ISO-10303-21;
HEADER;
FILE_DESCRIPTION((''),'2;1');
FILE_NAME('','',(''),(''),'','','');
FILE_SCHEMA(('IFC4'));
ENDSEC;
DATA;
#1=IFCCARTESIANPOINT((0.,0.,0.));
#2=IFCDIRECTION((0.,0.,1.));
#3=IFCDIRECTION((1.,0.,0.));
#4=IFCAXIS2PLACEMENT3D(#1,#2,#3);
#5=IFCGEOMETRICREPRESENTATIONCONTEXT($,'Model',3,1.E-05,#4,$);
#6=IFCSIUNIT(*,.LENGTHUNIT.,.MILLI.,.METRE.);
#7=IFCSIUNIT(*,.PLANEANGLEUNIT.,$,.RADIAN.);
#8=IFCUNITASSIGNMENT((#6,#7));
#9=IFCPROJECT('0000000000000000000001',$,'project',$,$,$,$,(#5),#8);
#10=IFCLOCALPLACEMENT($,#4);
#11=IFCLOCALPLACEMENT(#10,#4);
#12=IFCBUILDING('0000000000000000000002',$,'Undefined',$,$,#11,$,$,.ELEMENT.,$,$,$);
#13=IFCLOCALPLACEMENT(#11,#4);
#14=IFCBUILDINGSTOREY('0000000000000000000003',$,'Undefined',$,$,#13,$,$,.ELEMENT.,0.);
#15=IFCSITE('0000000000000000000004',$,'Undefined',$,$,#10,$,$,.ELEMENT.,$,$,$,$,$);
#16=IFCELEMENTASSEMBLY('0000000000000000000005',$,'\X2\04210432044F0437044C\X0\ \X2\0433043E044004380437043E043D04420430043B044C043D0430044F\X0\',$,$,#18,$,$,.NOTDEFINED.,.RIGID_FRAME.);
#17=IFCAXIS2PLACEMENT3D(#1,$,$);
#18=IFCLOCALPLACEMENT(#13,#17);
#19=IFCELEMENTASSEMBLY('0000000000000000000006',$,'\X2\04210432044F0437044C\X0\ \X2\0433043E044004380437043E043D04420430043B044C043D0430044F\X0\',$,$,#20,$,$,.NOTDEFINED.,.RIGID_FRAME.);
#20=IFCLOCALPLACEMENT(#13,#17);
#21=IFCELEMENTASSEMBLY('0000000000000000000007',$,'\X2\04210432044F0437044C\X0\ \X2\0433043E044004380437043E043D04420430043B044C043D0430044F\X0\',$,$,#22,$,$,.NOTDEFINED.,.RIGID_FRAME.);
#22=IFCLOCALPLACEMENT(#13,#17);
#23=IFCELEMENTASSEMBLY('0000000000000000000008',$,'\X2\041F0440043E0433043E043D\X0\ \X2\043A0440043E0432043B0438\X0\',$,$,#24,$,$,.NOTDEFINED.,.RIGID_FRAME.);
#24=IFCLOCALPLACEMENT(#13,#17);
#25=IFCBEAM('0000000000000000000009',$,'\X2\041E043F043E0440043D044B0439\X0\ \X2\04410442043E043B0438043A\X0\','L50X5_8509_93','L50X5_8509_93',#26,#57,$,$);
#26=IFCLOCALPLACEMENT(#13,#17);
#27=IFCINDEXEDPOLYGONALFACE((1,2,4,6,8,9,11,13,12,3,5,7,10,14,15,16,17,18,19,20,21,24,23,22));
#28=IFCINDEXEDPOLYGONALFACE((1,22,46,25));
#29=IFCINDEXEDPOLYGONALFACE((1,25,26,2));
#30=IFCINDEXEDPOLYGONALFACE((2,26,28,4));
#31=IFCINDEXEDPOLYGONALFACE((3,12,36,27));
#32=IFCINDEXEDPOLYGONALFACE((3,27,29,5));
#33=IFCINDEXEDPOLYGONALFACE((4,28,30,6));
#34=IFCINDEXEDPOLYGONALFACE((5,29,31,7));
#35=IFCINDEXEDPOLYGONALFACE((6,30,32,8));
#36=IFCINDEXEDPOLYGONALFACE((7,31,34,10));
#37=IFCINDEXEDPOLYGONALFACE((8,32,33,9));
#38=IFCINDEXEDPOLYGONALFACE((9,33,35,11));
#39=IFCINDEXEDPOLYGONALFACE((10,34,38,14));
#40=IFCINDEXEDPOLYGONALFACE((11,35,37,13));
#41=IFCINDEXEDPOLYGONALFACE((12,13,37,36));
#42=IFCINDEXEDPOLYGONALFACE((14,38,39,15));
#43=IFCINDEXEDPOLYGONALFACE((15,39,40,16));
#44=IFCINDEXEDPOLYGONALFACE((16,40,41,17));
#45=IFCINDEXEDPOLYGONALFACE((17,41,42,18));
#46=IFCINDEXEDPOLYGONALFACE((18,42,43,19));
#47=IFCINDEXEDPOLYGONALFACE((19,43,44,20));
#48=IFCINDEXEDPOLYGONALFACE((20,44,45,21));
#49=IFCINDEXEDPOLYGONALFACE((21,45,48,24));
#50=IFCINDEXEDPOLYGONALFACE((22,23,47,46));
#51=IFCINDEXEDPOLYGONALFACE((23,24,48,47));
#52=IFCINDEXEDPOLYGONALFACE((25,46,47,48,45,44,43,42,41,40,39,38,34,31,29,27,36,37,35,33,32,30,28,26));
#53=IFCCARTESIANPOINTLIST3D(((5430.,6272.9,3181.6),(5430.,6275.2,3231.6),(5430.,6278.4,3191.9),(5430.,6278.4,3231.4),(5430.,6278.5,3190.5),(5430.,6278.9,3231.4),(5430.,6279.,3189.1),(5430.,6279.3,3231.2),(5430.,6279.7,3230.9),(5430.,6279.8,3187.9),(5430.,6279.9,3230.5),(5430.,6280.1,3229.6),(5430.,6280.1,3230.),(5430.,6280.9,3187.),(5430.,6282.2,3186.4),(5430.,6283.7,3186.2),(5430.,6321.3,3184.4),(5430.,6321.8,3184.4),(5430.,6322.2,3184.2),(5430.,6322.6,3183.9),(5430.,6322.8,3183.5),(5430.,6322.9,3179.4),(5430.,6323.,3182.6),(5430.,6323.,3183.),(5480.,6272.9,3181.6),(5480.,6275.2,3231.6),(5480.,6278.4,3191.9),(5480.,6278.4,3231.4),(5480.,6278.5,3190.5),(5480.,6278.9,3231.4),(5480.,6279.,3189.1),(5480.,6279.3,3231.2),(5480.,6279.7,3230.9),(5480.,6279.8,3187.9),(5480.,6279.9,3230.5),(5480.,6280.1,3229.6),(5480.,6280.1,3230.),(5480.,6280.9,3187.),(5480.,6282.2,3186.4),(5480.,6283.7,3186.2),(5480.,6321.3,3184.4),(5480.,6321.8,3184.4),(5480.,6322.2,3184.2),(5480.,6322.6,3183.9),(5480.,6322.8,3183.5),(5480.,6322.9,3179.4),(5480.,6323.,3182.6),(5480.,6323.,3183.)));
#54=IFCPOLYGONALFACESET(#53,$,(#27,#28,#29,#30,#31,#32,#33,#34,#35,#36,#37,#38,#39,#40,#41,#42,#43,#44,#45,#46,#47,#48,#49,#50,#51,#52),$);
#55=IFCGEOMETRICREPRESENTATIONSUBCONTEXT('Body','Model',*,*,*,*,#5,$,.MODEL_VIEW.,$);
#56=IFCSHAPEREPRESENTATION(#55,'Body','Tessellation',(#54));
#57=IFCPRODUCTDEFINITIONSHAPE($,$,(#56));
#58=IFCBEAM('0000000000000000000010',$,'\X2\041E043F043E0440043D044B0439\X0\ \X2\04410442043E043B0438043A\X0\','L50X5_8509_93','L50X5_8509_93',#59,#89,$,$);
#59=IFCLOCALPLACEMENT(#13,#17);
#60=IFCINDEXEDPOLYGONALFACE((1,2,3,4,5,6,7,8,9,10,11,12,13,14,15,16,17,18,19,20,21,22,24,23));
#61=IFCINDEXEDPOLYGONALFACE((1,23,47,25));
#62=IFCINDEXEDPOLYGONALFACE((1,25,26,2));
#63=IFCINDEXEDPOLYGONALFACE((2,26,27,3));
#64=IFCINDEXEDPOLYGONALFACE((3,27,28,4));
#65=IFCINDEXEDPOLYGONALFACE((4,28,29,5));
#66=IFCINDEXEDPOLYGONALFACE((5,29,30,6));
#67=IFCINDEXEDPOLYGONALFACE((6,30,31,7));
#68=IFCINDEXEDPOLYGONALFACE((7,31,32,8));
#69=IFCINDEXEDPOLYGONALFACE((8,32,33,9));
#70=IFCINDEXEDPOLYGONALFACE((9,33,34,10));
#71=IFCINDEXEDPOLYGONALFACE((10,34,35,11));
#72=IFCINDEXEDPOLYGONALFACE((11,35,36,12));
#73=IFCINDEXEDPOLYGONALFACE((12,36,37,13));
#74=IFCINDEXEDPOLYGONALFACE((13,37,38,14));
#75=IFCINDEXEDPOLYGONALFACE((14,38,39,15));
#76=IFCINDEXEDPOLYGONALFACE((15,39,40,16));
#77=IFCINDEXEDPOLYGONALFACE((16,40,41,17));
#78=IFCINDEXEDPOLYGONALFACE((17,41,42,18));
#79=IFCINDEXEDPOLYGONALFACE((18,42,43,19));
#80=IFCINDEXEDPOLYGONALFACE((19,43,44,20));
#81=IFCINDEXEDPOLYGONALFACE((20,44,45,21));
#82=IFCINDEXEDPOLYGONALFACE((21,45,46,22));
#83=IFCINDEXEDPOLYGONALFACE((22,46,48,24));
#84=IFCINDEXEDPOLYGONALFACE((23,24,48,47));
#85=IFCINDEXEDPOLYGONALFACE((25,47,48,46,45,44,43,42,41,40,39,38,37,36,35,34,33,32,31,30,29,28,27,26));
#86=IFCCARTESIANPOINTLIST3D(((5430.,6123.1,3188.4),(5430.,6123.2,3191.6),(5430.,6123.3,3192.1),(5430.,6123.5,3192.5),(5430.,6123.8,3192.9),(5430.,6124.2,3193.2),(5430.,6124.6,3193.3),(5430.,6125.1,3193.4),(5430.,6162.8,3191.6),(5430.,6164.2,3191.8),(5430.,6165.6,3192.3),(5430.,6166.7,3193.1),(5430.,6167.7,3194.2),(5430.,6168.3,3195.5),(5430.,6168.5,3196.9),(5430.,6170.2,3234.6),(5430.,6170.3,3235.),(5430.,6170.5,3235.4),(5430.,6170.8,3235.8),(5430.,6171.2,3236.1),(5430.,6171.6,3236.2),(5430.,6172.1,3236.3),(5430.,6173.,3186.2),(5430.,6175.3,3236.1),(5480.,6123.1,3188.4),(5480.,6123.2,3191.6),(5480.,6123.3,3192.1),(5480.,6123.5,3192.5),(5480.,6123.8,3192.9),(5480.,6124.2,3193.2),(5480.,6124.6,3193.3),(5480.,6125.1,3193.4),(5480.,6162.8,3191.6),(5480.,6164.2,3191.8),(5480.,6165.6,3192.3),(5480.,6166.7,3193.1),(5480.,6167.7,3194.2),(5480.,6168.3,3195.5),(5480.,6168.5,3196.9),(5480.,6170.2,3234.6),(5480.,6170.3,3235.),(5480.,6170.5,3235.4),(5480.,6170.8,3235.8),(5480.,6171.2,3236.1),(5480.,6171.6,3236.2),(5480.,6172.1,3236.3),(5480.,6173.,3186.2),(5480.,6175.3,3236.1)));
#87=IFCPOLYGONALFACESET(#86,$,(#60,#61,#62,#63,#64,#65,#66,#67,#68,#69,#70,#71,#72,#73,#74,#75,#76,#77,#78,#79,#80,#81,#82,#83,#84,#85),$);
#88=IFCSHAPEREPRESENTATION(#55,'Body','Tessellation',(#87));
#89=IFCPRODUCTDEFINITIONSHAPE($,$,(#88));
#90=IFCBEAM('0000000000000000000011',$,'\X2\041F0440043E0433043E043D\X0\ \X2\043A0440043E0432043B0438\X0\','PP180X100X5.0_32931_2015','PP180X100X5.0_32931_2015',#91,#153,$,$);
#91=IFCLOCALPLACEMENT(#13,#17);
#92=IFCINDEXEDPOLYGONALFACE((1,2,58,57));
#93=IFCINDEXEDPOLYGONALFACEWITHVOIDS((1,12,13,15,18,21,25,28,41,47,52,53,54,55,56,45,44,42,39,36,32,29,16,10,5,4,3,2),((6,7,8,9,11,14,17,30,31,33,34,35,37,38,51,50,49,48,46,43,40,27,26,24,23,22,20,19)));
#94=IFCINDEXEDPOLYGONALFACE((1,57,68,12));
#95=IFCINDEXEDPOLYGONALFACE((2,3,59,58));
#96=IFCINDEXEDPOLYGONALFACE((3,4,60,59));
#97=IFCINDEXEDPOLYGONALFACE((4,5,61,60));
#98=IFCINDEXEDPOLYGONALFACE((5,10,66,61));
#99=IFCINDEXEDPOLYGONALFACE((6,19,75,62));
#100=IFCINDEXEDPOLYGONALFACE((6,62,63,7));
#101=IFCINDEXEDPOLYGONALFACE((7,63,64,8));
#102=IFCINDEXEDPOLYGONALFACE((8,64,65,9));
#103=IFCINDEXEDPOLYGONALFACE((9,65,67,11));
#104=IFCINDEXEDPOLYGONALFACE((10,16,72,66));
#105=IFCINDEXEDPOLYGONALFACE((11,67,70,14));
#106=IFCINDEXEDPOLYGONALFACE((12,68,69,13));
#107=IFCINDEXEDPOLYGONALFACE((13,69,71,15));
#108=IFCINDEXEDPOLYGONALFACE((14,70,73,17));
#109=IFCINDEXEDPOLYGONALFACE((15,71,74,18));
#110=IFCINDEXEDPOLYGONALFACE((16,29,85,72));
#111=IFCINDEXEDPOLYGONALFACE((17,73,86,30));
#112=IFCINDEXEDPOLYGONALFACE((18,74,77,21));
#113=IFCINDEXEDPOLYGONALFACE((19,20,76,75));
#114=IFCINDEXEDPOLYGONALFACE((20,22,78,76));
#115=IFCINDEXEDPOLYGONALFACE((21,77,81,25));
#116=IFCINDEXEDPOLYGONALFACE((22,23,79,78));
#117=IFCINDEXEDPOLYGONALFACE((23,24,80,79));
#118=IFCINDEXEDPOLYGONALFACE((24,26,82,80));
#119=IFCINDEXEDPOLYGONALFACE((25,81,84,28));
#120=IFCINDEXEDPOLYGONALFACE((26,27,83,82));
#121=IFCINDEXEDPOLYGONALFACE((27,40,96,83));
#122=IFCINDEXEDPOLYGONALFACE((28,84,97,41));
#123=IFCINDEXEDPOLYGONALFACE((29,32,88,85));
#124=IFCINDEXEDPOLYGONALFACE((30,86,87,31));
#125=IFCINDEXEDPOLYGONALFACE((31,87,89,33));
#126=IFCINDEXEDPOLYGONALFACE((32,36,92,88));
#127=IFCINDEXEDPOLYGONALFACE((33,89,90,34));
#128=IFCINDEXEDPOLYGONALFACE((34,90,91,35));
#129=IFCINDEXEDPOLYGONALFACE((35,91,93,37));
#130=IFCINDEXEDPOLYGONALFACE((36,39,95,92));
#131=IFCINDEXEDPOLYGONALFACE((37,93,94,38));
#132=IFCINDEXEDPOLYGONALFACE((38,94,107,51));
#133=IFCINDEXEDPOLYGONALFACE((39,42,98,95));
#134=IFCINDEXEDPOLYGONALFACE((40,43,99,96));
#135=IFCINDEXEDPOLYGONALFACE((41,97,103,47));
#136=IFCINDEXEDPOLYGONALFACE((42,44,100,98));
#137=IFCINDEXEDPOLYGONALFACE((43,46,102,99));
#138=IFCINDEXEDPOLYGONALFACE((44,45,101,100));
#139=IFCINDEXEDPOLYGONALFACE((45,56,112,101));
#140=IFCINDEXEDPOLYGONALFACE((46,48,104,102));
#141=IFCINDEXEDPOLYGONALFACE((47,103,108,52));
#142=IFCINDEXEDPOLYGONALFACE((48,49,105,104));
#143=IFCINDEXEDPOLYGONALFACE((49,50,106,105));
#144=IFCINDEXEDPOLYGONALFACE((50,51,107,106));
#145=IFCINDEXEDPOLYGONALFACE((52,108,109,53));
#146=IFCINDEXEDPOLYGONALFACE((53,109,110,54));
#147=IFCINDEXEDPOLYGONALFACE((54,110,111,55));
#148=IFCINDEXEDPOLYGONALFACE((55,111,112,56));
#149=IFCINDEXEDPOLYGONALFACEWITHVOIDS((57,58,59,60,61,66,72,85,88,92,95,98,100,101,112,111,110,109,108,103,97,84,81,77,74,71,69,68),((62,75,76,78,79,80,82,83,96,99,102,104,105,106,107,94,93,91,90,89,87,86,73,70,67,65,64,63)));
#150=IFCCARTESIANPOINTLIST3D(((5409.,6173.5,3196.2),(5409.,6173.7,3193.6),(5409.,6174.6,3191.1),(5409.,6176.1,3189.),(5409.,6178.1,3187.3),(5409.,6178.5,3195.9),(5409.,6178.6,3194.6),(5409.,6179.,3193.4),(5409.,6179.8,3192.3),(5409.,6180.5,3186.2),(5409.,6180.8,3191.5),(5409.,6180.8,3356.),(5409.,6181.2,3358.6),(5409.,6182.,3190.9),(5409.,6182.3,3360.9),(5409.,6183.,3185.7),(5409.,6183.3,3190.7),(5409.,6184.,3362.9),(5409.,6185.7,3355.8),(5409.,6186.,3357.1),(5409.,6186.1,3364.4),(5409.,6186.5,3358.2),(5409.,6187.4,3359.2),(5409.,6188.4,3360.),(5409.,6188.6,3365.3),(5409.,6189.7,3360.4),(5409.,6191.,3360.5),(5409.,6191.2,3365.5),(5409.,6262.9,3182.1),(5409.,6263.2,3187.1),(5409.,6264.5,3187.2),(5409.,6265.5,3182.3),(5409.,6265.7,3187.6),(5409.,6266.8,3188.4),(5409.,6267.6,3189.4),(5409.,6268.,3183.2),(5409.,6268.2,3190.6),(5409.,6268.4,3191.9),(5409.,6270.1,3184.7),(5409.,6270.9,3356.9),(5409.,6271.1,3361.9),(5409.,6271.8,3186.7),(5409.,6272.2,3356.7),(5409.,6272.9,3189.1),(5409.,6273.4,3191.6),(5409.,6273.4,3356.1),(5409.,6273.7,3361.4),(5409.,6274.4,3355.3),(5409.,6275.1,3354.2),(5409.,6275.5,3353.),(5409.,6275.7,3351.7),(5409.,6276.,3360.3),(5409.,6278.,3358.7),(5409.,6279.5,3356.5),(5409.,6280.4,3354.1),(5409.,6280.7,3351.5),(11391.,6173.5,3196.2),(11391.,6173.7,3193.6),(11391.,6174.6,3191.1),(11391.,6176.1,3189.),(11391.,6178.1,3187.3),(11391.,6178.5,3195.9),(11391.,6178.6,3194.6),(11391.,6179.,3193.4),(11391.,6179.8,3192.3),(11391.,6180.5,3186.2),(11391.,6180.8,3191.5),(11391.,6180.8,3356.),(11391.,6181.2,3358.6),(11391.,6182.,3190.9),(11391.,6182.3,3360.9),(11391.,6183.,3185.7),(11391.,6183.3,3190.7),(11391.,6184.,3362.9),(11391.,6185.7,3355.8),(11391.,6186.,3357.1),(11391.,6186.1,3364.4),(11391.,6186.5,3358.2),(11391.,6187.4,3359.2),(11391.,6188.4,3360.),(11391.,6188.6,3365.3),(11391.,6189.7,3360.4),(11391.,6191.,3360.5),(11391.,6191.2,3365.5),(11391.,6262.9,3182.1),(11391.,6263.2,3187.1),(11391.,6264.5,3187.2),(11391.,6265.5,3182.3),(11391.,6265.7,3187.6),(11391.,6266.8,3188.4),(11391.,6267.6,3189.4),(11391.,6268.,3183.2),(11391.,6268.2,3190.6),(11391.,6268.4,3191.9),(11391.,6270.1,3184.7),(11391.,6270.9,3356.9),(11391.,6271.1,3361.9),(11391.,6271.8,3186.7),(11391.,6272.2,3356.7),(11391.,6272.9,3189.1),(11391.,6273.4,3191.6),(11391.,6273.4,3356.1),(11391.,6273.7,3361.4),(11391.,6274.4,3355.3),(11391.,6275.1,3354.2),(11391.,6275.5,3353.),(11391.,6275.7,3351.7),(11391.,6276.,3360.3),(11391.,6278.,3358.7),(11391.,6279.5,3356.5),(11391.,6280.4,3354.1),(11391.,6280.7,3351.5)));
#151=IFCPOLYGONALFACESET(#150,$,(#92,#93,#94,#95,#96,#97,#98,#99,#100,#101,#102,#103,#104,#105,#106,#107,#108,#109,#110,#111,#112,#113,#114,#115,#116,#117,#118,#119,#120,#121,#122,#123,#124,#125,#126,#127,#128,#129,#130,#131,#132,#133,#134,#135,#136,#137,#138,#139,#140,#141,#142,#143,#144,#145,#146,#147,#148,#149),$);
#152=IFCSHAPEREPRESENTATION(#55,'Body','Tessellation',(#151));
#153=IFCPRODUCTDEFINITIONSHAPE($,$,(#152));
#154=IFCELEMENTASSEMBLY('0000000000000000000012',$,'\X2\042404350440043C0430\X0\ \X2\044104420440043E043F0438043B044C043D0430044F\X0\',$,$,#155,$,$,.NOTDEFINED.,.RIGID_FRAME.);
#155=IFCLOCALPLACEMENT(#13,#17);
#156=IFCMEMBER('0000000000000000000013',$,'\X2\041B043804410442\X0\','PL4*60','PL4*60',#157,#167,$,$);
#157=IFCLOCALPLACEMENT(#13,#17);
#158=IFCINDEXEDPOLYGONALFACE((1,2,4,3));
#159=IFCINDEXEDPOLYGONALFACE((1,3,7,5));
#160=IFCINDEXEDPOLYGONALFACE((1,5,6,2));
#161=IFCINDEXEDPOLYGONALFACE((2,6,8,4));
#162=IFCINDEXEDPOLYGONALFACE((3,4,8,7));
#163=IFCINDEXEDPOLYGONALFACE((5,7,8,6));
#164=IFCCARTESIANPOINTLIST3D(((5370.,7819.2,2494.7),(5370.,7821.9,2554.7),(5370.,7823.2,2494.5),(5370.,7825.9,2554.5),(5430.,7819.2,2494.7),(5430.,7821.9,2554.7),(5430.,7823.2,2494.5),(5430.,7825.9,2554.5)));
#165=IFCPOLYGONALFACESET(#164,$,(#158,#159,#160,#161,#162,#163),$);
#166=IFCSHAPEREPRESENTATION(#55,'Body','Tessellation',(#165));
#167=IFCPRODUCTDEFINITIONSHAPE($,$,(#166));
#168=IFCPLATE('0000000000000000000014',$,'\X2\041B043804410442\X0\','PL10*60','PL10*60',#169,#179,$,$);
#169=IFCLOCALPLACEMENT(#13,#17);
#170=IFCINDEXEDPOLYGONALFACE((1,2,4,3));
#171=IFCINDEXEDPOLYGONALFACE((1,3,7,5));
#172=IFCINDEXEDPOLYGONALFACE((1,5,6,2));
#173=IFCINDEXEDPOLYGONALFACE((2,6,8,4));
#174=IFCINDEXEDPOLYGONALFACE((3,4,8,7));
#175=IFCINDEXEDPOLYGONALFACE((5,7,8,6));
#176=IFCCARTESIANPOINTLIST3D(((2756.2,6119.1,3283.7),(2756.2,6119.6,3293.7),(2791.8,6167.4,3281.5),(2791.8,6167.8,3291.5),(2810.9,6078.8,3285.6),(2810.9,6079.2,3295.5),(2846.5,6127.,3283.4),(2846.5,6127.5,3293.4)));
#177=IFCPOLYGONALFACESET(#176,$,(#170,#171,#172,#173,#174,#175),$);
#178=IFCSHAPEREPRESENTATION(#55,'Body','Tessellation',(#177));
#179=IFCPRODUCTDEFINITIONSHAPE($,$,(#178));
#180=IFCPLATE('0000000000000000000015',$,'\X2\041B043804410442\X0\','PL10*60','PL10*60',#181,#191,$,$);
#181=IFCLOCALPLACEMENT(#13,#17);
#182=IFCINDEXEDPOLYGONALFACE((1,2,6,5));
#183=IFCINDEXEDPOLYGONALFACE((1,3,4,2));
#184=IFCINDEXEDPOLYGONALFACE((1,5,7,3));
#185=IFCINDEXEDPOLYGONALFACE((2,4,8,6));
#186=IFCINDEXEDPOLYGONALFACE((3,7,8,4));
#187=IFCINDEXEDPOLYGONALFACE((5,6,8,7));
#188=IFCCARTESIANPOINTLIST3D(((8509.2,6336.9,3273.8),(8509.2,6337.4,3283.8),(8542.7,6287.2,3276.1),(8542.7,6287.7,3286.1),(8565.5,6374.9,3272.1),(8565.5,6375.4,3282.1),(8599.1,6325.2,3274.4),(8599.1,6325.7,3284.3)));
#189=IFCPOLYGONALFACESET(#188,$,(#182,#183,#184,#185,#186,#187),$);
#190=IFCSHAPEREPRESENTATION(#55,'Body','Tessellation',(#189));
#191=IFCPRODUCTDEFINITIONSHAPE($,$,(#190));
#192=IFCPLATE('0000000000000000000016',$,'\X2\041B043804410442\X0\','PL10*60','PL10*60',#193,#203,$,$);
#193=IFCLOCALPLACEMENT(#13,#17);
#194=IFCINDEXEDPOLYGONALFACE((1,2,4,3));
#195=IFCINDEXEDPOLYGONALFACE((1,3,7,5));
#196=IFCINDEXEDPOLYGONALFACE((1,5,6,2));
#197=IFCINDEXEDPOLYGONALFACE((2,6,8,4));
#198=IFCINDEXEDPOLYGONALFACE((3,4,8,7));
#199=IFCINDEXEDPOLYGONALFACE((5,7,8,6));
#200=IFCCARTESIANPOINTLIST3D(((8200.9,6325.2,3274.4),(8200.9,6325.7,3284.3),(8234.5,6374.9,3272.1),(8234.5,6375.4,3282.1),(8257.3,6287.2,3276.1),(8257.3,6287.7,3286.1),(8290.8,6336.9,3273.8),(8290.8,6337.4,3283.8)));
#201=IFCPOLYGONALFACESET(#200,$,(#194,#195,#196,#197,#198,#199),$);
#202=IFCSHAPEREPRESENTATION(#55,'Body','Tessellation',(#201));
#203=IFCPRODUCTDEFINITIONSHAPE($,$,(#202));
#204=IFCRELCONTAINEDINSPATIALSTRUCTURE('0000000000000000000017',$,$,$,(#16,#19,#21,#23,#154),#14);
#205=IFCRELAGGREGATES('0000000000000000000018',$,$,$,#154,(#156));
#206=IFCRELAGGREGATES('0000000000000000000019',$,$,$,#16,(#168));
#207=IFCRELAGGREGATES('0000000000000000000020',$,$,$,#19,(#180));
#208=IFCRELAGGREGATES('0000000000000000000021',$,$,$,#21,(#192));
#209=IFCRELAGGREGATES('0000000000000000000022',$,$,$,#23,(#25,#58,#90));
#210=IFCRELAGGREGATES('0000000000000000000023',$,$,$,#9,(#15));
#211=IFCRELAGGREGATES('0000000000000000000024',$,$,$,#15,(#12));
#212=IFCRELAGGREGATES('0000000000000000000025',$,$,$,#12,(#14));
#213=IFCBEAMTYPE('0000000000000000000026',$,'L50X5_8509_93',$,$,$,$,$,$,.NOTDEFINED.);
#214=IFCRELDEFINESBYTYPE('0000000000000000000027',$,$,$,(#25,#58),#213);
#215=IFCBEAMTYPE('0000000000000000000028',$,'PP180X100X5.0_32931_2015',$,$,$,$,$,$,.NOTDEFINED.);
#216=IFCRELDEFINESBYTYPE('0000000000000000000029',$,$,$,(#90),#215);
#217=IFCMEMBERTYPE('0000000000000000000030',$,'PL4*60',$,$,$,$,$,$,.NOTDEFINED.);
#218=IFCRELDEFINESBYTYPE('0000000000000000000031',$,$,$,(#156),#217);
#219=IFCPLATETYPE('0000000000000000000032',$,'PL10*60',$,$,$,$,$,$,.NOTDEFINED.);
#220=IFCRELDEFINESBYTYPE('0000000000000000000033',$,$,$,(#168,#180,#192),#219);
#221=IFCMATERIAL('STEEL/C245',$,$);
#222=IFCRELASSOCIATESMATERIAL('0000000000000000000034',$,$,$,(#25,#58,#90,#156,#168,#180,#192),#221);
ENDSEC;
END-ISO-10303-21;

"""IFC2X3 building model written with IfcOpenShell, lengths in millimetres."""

from ifc_helpers import new_model, si_unit, frame, origin_with_axes, origin_2d_with_axis, place, context, subcontext, project, spatial, polyline, rectangle, hollow_rectangle, l_section, outline, extrude, clip, halfspace, material, type_object, element, aggregate, save


model = new_model("IFC2X3")

# Units and contexts
model_context = context("Model", 3, precision=1e-05, world=origin_with_axes())
body_context = subcontext(model_context, "Body", "Model", "MODEL_VIEW")
ifc_project = project(units=[si_unit("LENGTHUNIT", "METRE", prefix="MILLI"), si_unit("PLANEANGLEUNIT", "RADIAN")], contexts=[model_context])

# Site, building, storey
site_placement = place(None, origin_with_axes())
site = spatial("IfcSite", under=ifc_project, at=site_placement, Name="Undefined", CompositionType="ELEMENT")
building_placement = place(site_placement, origin_with_axes())
building = spatial("IfcBuilding", under=site, at=building_placement, Name="Undefined", CompositionType="ELEMENT")
storey_placement = place(building_placement, origin_with_axes())
storey = spatial("IfcBuildingStorey", under=building, at=storey_placement, Name="Undefined", CompositionType="ELEMENT", Elevation=0.0)

# Element assembly
assembly_1_placement = place(storey_placement, origin_with_axes())
assembly_1 = element("IfcElementAssembly", 1, at=assembly_1_placement, inside=storey, Name="Связь горизонтальная", AssemblyPlace="NOTDEFINED", PredefinedType="RIGID_FRAME")
ifc_material_1 = material(Name="STEEL/C245")

# Element assembly
assembly_2_placement = place(storey_placement, origin_with_axes())
assembly_2 = element("IfcElementAssembly", 2, at=assembly_2_placement, inside=storey, Name="Связь горизонтальная", AssemblyPlace="NOTDEFINED", PredefinedType="RIGID_FRAME")

# Element assembly
assembly_3_placement = place(storey_placement, origin_with_axes())
assembly_3 = element("IfcElementAssembly", 3, at=assembly_3_placement, inside=storey, Name="Связь горизонтальная", AssemblyPlace="NOTDEFINED", PredefinedType="RIGID_FRAME")

# Element assembly
assembly_4_placement = place(storey_placement, origin_with_axes())
assembly_4 = element("IfcElementAssembly", 4, at=assembly_4_placement, inside=storey, Name="Прогон кровли", AssemblyPlace="NOTDEFINED", PredefinedType="RIGID_FRAME")

# Beams
beam_type_1 = type_object("IfcBeamType", Name="L50X5_8509_93", PredefinedType="NOTDEFINED")
beam_1_placement = place(assembly_4_placement, frame((5430.0, 6299.0, 3205.5), z_axis=(0.0, 0.998969, -0.045408), x_axis=(1.0, 0.0, 0.0)))
beam_1 = element("IfcBeam", 5, at=beam_1_placement, type_object=beam_type_1, material=ifc_material_1, Name="Опорный столик", Description="L50X5_8509_93", ObjectType="L50X5_8509_93", context=body_context, shape_type="SweptSolid", body=[
    extrude(l_section(Depth=50.0, Width=50.0, Thickness=5.0, FilletRadius=5.5, EdgeRadius=1.8, at=origin_2d_with_axis()), frame((50.0, 0.0, 0.0), z_axis=(-1.0, 0.0, 0.0), x_axis=(0.0, -1.0, 0.0)), (0.0, 0.0, 1.0), 50.0),
])
beam_2_placement = place(assembly_4_placement, frame((5480.0, 6149.2, 3212.3), z_axis=(0.0, -0.998969, 0.045408), x_axis=(-1.0, 0.0, 0.0)))
beam_2 = element("IfcBeam", 6, at=beam_2_placement, type_object=beam_type_1, material=ifc_material_1, Name="Опорный столик", Description="L50X5_8509_93", ObjectType="L50X5_8509_93", context=body_context, shape_type="SweptSolid", body=[
    extrude(l_section(Depth=50.0, Width=50.0, Thickness=5.0, FilletRadius=5.5, EdgeRadius=1.8, at=origin_2d_with_axis()), frame((50.0, 0.0, 0.0), z_axis=(-1.0, 0.0, 0.0), x_axis=(0.0, -1.0, 0.0)), (0.0, 0.0, 1.0), 50.0),
])
beam_type_2 = type_object("IfcBeamType", Name="PP180X100X5.0_32931_2015", PredefinedType="NOTDEFINED")
beam_3_placement = place(assembly_4_placement, frame((5405.0, 6227.1, 3273.8), z_axis=(0.0, 0.045408, 0.998969), x_axis=(1.0, 0.0, 0.0)))
beam_3 = element("IfcBeam", 7, at=beam_3_placement, type_object=beam_type_2, material=ifc_material_1, Name="Прогон кровли", Description="PP180X100X5.0_32931_2015", ObjectType="PP180X100X5.0_32931_2015", context=body_context, shape_type="Clipping", body=[
    clip(clip(extrude(hollow_rectangle(XDim=100.0, YDim=180.0, WallThickness=5.0, InnerFilletRadius=5.0, OuterFilletRadius=10.0, at=origin_2d_with_axis()), frame((5986.0, 0.0, 0.0), z_axis=(-1.0, 0.0, 0.0), x_axis=(0.0, -1.0, 0.0)), (0.0, 0.0, 1.0), 5982.0), halfspace(frame((5986.0, 0.0, -90.0), z_axis=(-1.0, 0.0, 0.0), x_axis=(0.0, 1.0, 0.0)), True)), halfspace(frame((4.0, 0.0, -90.0), z_axis=(1.0, 0.0, 0.0), x_axis=(0.0, -1.0, 0.0)), True)),
])

# Element assembly, member
assembly_5_placement = place(storey_placement, origin_with_axes())
assembly_5 = element("IfcElementAssembly", 8, at=assembly_5_placement, inside=storey, Name="Ферма стропильная", AssemblyPlace="NOTDEFINED", PredefinedType="RIGID_FRAME")
member_type_1 = type_object("IfcMemberType", Name="PL4*60", PredefinedType="NOTDEFINED")
member_1_placement = place(assembly_5_placement, frame((5400.0, 7821.2, 2494.6), z_axis=(-1.0, 0.0, 0.0), x_axis=(0.0, 0.045408, 0.998969)))
member_1 = element("IfcMember", 9, at=member_1_placement, type_object=member_type_1, material=ifc_material_1, Name="Лист", Description="PL4*60", ObjectType="PL4*60", context=body_context, shape_type="SweptSolid", body=[
    extrude(rectangle(XDim=4.0, YDim=60.0, at=origin_2d_with_axis()), frame((60.0, 0.0, 0.0), z_axis=(-1.0, 0.0, 0.0), x_axis=(0.0, -1.0, 0.0)), (0.0, 0.0, 1.0), 60.0),
])

# Plates
plate_type_1 = type_object("IfcPlateType", Name="PL10*60", PredefinedType="NOTDEFINED")
plate_1_placement = place(assembly_1_placement, frame((2774.0, 6143.5, 3287.6), z_axis=(0.0, -0.045408, -0.998969), x_axis=(0.804616, -0.593183, 0.026963)))
plate_1 = element("IfcPlate", 10, at=plate_1_placement, type_object=plate_type_1, material=ifc_material_1, Name="Лист", Description="PL10*60", ObjectType="PL10*60", context=body_context, shape_type="SweptSolid", body=[
    extrude(outline(polyline([(0.0, 30.0), (68.0, 30.0), (68.0, -30.0), (0.0, -30.0), (0.0, 30.0)])), frame((0.0, 0.0, -5.0), z_axis=(0.0, 0.0, 1.0), x_axis=(1.0, 0.0, 0.0)), (0.0, 0.0, 1.0), 10.0),
])
plate_2_placement = place(assembly_2_placement, frame((8525.9, 6312.3, 3280.0), z_axis=(0.0, -0.045408, -0.998969), x_axis=(0.829223, 0.558342, -0.025379)))
plate_2 = element("IfcPlate", 11, at=plate_2_placement, type_object=plate_type_1, material=ifc_material_1, Name="Лист", Description="PL10*60", ObjectType="PL10*60", context=body_context, shape_type="SweptSolid", body=[
    extrude(outline(polyline([(0.0, -30.0), (0.0, 30.0), (68.0, 30.0), (68.0, -30.0), (0.0, -30.0)])), frame((0.0, 0.0, -5.0), z_axis=(0.0, 0.0, 1.0), x_axis=(1.0, 0.0, 0.0)), (0.0, 0.0, 1.0), 10.0),
])
plate_3_placement = place(assembly_3_placement, frame((8274.1, 6312.3, 3280.0), z_axis=(0.0, -0.045408, -0.998969), x_axis=(-0.829223, 0.558342, -0.025379)))
plate_3 = element("IfcPlate", 12, at=plate_3_placement, type_object=plate_type_1, material=ifc_material_1, Name="Лист", Description="PL10*60", ObjectType="PL10*60", context=body_context, shape_type="SweptSolid", body=[
    extrude(outline(polyline([(68.0, -30.0), (0.0, -30.0), (0.0, 30.0), (68.0, 30.0), (68.0, -30.0)])), frame((0.0, 0.0, -5.0), z_axis=(0.0, 0.0, 1.0), x_axis=(1.0, 0.0, 0.0)), (0.0, 0.0, 1.0), 10.0),
])
aggregate(assembly_5, [member_1])

aggregate(assembly_1, [plate_1])
aggregate(assembly_2, [plate_2])
aggregate(assembly_3, [plate_3])
aggregate(assembly_4, [beam_1, beam_2, beam_3])

save(model, "model.ifc")
